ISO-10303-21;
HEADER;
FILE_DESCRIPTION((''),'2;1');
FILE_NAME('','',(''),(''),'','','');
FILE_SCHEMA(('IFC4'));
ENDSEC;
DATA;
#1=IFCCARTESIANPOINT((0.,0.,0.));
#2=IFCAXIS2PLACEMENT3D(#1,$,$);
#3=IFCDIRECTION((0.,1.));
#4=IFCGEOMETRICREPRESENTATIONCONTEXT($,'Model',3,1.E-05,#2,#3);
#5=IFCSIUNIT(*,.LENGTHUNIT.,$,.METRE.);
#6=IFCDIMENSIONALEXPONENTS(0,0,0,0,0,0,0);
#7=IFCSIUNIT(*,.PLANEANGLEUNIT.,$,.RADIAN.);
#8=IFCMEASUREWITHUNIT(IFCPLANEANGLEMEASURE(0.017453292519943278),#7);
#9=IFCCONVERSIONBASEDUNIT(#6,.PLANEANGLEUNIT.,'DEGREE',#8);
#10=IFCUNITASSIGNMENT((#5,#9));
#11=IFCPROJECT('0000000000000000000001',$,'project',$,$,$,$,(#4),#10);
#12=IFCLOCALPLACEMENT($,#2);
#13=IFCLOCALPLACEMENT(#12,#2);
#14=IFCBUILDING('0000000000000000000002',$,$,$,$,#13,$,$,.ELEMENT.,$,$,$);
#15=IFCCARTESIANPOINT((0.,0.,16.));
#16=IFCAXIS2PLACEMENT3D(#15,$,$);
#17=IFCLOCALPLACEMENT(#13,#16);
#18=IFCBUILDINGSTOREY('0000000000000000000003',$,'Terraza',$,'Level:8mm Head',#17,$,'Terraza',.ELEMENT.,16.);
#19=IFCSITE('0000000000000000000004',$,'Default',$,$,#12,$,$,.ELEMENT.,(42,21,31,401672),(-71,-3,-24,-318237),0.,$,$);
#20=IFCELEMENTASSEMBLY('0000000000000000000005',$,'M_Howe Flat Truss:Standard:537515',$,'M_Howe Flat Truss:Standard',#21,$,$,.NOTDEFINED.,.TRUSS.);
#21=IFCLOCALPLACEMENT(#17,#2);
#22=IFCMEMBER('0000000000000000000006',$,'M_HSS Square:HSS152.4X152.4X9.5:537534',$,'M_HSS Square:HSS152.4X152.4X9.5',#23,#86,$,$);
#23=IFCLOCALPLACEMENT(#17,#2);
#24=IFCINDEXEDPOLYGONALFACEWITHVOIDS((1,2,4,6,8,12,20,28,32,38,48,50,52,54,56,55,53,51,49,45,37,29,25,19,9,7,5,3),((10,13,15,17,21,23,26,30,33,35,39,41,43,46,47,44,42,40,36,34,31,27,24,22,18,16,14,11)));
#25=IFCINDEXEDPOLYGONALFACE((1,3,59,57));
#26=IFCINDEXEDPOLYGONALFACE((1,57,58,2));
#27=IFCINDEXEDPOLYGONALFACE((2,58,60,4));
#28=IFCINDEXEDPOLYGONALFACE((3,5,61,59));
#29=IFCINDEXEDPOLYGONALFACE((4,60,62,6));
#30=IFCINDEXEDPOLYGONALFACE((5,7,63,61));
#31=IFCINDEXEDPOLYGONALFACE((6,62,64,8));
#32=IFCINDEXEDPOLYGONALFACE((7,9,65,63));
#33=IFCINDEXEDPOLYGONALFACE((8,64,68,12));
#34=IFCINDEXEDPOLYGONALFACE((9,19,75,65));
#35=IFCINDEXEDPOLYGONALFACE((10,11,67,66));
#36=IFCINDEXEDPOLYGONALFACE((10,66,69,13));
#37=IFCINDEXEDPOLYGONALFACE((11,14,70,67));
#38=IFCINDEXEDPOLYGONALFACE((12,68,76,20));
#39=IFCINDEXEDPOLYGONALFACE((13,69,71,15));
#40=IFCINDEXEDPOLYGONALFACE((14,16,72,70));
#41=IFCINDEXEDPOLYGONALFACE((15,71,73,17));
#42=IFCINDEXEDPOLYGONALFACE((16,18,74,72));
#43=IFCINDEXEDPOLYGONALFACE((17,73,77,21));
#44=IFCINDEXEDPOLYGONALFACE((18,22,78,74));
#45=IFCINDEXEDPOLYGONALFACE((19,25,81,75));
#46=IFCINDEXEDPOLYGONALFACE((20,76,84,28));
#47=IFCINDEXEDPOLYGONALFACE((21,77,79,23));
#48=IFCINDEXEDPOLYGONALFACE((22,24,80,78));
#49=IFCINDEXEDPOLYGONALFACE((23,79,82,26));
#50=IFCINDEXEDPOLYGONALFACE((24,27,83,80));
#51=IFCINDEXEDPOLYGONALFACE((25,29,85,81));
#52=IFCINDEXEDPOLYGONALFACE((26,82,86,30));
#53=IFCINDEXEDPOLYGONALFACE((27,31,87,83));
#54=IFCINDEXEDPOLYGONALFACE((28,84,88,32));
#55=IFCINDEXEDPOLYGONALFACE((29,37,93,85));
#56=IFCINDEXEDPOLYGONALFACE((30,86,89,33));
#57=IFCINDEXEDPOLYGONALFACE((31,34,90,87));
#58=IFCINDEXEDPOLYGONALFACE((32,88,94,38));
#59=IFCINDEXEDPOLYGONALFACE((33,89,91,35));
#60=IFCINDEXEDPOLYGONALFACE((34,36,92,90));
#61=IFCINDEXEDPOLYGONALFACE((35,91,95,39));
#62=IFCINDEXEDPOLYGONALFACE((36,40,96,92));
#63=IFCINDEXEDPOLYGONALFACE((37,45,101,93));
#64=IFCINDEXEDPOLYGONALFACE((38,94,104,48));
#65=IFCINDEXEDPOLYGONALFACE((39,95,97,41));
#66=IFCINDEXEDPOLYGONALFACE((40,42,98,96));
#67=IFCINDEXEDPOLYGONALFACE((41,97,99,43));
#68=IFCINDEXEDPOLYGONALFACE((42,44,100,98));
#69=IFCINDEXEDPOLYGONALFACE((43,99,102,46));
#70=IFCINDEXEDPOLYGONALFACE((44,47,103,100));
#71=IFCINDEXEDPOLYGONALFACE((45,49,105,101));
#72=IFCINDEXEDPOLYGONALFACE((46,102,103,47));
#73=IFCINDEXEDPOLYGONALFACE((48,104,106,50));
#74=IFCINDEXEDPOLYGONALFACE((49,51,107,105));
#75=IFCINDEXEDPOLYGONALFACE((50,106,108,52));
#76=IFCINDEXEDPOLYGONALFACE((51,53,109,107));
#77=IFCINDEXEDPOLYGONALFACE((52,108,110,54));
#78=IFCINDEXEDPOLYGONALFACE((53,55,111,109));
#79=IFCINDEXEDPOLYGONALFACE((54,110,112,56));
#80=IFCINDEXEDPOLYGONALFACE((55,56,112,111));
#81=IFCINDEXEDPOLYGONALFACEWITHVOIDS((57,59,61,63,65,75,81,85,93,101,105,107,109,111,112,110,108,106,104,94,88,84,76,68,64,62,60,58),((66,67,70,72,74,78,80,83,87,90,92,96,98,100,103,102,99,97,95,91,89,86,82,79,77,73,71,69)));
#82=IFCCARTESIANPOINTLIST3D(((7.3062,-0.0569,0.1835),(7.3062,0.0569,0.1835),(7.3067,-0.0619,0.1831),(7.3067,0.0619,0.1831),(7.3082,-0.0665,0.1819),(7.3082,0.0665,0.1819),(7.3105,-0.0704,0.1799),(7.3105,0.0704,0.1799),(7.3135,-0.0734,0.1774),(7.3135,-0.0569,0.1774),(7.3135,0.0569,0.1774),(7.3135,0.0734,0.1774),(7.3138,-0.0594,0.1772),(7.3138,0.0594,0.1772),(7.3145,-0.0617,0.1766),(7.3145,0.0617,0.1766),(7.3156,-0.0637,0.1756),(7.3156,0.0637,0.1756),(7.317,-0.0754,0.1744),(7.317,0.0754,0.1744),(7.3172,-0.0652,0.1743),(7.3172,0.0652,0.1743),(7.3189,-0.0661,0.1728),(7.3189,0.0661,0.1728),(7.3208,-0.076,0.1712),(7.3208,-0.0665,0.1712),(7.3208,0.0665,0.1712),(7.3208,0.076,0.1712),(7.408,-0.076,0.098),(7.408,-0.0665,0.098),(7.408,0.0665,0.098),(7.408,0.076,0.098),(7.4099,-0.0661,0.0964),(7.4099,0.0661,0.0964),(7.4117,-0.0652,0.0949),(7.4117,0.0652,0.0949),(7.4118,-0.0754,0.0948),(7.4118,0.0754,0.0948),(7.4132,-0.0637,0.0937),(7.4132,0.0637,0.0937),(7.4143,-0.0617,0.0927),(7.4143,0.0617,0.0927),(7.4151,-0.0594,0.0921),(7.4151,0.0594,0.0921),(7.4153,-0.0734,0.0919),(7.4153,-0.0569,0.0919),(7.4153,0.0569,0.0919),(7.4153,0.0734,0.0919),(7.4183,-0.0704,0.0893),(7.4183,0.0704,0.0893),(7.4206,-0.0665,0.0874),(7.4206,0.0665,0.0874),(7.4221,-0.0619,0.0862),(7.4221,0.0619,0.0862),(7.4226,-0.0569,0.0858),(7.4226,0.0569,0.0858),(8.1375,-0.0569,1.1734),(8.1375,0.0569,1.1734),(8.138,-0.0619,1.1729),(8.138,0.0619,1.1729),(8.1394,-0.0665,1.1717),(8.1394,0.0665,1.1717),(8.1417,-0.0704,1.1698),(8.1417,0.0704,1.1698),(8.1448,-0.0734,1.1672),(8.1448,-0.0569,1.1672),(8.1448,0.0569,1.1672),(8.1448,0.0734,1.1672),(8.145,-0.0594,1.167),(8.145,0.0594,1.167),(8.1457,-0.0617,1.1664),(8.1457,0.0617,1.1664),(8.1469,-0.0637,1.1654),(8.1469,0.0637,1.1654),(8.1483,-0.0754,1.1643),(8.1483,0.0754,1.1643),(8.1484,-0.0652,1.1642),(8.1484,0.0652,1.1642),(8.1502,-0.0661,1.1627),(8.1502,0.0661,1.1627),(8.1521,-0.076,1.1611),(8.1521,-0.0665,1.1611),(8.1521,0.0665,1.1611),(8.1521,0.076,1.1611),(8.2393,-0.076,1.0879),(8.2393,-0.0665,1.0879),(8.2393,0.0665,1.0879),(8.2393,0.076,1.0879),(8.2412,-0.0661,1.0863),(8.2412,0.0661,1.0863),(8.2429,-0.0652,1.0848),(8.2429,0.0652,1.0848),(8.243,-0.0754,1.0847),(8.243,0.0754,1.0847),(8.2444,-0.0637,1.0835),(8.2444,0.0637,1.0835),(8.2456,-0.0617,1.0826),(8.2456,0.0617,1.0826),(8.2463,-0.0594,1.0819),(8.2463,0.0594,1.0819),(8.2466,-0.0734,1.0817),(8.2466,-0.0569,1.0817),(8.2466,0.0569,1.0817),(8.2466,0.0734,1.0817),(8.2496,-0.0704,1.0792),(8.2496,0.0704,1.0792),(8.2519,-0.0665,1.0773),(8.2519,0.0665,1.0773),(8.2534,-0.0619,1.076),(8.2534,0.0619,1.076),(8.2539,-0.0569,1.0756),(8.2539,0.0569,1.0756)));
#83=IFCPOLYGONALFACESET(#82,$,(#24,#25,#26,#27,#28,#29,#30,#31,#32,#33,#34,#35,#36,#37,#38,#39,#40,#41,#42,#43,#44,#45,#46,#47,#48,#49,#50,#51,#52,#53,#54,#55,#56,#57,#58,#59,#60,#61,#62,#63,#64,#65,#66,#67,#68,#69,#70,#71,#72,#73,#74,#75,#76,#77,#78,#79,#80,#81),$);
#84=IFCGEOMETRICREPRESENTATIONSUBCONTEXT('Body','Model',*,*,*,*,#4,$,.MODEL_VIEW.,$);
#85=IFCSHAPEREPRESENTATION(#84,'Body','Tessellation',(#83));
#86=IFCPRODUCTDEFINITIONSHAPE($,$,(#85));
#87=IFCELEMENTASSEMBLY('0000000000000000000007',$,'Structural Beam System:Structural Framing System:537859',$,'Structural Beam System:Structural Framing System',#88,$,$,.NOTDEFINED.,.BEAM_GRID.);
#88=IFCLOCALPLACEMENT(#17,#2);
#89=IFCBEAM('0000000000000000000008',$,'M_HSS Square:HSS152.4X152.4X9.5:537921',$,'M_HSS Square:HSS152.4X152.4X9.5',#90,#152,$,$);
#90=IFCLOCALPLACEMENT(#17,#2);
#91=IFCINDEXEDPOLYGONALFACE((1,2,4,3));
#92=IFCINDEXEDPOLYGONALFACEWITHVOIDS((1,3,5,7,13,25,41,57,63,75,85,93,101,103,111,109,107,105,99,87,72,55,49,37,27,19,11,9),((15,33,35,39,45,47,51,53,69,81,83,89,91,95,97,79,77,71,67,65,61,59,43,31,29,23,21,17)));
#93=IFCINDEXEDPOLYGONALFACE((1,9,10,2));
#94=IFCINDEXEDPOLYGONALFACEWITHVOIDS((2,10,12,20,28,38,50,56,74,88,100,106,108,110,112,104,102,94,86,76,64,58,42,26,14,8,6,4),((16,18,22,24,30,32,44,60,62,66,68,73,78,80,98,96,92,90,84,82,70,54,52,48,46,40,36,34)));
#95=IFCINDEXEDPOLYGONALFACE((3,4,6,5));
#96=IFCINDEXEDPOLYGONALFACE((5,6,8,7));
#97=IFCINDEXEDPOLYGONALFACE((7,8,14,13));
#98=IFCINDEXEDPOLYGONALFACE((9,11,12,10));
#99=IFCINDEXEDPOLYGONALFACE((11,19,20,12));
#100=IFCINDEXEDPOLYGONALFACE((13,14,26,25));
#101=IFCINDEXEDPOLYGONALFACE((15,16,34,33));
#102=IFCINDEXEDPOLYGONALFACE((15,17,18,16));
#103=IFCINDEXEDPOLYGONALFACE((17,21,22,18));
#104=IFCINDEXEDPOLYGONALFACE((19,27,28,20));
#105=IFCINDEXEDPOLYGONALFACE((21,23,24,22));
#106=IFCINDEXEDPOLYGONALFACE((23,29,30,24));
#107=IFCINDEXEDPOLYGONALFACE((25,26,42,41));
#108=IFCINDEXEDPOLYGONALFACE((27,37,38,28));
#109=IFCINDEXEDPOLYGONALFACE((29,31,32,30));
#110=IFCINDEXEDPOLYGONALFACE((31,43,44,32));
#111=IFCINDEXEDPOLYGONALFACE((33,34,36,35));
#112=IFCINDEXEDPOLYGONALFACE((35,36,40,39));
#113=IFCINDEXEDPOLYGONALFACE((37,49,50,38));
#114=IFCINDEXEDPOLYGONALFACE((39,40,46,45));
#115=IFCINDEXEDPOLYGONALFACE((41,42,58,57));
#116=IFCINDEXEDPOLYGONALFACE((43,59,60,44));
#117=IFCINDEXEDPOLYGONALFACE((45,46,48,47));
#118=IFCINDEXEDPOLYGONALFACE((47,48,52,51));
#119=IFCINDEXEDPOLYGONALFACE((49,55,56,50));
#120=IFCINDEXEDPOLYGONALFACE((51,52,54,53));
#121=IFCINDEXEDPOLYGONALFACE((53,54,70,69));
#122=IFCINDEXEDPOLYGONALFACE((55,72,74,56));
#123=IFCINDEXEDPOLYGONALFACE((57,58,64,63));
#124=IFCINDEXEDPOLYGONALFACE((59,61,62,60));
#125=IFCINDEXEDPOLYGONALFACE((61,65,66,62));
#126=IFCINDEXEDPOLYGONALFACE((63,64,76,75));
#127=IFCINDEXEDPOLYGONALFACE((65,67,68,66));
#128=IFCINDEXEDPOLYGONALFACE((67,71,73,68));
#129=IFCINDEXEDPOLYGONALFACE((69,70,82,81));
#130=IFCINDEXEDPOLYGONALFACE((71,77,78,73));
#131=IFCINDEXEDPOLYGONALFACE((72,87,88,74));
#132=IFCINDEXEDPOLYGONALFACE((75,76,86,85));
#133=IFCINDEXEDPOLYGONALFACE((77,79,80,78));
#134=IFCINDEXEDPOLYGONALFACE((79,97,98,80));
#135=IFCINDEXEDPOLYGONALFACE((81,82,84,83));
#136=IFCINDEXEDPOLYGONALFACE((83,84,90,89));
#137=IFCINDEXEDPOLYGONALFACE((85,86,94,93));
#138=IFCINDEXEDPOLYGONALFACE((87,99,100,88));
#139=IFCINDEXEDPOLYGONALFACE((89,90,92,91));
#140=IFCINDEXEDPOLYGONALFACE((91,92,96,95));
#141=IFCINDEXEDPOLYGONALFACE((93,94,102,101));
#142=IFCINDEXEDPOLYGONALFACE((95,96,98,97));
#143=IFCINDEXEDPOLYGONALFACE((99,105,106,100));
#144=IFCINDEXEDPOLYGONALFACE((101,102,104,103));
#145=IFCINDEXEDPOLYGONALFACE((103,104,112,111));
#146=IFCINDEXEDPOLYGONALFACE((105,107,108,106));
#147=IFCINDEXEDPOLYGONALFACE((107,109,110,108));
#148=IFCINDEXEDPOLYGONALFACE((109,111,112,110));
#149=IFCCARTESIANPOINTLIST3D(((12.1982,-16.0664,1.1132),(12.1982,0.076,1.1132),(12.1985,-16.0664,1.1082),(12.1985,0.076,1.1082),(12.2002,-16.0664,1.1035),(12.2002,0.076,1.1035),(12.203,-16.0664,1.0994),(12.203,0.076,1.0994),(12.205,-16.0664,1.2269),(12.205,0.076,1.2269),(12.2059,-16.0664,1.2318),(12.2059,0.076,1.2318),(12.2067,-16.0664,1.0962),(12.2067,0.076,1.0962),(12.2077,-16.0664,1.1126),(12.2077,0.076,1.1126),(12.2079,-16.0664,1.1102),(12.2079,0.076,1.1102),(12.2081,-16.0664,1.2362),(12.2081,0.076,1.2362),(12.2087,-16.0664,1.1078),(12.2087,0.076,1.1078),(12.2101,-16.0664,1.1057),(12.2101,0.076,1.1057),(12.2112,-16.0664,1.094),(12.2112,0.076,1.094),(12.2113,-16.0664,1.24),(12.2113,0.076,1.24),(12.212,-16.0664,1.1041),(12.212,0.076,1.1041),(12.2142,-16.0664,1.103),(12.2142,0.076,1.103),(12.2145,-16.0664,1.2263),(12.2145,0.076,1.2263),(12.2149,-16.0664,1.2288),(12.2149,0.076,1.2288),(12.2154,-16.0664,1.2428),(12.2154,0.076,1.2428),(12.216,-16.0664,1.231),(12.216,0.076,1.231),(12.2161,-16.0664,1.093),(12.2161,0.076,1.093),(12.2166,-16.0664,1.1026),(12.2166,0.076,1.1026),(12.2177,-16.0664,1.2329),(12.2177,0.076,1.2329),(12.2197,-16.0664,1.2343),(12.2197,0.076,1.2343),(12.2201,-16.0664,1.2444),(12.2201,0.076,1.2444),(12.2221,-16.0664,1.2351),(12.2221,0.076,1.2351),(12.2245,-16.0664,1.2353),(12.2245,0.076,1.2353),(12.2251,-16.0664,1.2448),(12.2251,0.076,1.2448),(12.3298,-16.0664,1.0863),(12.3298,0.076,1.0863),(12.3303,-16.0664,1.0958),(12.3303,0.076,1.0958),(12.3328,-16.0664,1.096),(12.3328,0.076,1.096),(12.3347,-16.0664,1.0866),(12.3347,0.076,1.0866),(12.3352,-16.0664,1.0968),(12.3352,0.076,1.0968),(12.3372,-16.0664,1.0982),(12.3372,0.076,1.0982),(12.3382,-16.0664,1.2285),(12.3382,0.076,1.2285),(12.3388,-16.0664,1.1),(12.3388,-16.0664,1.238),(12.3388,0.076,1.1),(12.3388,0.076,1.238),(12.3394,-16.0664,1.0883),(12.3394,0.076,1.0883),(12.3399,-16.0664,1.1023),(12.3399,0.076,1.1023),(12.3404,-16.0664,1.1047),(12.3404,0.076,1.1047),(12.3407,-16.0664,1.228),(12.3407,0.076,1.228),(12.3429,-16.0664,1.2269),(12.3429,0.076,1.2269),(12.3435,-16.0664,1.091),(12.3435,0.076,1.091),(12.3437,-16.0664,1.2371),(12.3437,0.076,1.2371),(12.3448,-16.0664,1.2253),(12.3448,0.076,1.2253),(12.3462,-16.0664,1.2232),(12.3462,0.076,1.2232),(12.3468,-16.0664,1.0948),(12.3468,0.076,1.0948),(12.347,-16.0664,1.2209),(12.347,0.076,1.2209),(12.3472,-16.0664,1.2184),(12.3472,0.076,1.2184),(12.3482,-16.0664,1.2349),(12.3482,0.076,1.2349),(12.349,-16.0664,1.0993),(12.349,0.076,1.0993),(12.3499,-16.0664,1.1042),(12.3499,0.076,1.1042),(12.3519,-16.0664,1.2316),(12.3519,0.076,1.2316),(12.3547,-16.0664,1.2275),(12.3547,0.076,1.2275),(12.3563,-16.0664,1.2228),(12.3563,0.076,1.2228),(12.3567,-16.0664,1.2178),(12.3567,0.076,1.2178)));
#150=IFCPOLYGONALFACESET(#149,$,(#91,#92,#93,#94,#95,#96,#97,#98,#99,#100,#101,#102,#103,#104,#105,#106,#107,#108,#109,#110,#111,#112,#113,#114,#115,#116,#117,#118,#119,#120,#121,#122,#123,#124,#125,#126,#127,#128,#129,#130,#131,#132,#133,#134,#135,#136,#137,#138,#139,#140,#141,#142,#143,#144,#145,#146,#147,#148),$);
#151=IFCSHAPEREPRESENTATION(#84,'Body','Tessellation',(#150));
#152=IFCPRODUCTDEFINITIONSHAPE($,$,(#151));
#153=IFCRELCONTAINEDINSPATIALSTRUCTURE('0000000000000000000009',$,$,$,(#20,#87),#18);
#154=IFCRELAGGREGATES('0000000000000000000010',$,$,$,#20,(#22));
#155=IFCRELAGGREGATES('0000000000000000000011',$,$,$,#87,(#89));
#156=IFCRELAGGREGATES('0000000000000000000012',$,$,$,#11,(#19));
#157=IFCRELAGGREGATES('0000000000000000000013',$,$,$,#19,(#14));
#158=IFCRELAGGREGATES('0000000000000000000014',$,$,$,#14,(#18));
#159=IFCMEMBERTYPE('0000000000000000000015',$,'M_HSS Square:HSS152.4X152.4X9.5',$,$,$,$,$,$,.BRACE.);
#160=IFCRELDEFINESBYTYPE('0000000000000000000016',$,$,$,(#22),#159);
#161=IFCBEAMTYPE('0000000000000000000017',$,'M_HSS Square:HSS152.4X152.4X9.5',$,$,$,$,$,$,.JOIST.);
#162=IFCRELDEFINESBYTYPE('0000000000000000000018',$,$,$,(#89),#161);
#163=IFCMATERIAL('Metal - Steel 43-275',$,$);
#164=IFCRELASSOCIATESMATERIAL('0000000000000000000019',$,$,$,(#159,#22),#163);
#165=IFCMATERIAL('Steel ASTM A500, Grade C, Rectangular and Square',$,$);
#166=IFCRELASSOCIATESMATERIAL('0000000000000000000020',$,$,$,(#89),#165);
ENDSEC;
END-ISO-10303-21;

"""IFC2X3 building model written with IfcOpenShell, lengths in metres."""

from ifc_helpers import new_model, entity, si_unit, converted_unit, direction, frame, frame_2d, origin, place, context, subcontext, project, spatial, polyline, circle_curve, parameter, trimmed, segment, composite_curve, outline, extrude, source, transform, mapped, material, type_object, type_shapes, element, aggregate, save


model = new_model("IFC2X3")

# Units and contexts
model_context = context("Model", 3, precision=1e-05, world=origin(), true_north=direction((0.0, 1.0)))
body_context = subcontext(model_context, "Body", "Model", "MODEL_VIEW")
ifc_project = project(units=[si_unit("LENGTHUNIT", "METRE"), converted_unit("PLANEANGLEUNIT", "DEGREE", entity("IfcPlaneAngleMeasure", 0.017453292519943278), si_unit("PLANEANGLEUNIT", "RADIAN"), dimensions=[0, 0, 0, 0, 0, 0, 0])], contexts=[model_context])

# Site, building, storey
site_placement = place(None, origin())
site = spatial("IfcSite", under=ifc_project, at=site_placement, Name="Default", CompositionType="ELEMENT", RefLatitude=(42, 21, 31, 401672), RefLongitude=(-71, -3, -24, -318237), RefElevation=0.0)
building_placement = place(site_placement, origin())
building = spatial("IfcBuilding", under=site, at=building_placement, CompositionType="ELEMENT")
storey_placement = place(building_placement, frame((0.0, 0.0, 16.0)))
storey = spatial("IfcBuildingStorey", under=building, at=storey_placement, Name="Terraza", ObjectType="Level:8mm Head", LongName="Terraza", CompositionType="ELEMENT", Elevation=16.0)

# Element assembly
ifc_material_1 = material(Name="Metal - Steel 43-275")
assembly_1_placement = place(storey_placement, origin())
assembly_1 = element("IfcElementAssembly", 1, at=assembly_1_placement, inside=storey, Name="M_Howe Flat Truss:Standard:537515", ObjectType="M_Howe Flat Truss:Standard", AssemblyPlace="NOTDEFINED", PredefinedType="TRUSS")

# Member
member_type_1 = type_object("IfcMemberType", Name="M_HSS Square:HSS152.4X152.4X9.5", PredefinedType="BRACE", material=ifc_material_1)
shared_shape_1 = source(origin(), body_context, "Body", "SweptSolid", [
    extrude(outline(composite_curve([segment(polyline([(-0.0569, -0.076), (0.0569, -0.076)]), True, "CONTINUOUS"), segment(trimmed(circle_curve(frame_2d((0.0569, -0.0569), x_axis=(0.0, 1.0)), 0.0191), [parameter(180.0)], [parameter(270.0)], True, "PARAMETER"), True, "CONTINUOUS"), segment(polyline([(0.076, -0.0569), (0.076, 0.0569)]), True, "CONTINUOUS"), segment(trimmed(circle_curve(frame_2d((0.0569, 0.0569), x_axis=(0.0, 1.0)), 0.0191), [parameter(270.0)], [parameter(0.0)], True, "PARAMETER"), True, "CONTINUOUS"), segment(polyline([(0.0569, 0.076), (-0.0569, 0.076)]), True, "CONTINUOUS"), segment(trimmed(circle_curve(frame_2d((-0.0569, 0.0569), x_axis=(0.0, 1.0)), 0.0191), [parameter(0.0)], [parameter(90.0)], True, "PARAMETER"), True, "CONTINUOUS"), segment(polyline([(-0.076, 0.0569), (-0.076, -0.0569)]), True, "CONTINUOUS"), segment(trimmed(circle_curve(frame_2d((-0.0569, -0.0569), x_axis=(0.0, 1.0)), 0.0191), [parameter(90.0)], [parameter(180.0)], True, "PARAMETER"), True, "CONTINUOUS")], self_intersect=False), holes=[composite_curve([segment(trimmed(circle_curve(frame_2d((-0.0569, 0.0569), x_axis=(0.0, 1.0)), 0.0095), [parameter(360.0)], [parameter(90.0)], True, "PARAMETER"), False, "CONTINUOUS"), segment(polyline([(-0.0569, 0.0665), (0.0569, 0.0665)]), True, "CONTINUOUS"), segment(trimmed(circle_curve(frame_2d((0.0569, 0.0569), x_axis=(0.0, 1.0)), 0.0095), [parameter(270.0)], [parameter(360.0)], True, "PARAMETER"), False, "CONTINUOUS"), segment(polyline([(0.0665, 0.0569), (0.0665, -0.0569)]), True, "CONTINUOUS"), segment(trimmed(circle_curve(frame_2d((0.0569, -0.0569), x_axis=(0.0, 1.0)), 0.0095), [parameter(180.0)], [parameter(270.0)], True, "PARAMETER"), False, "CONTINUOUS"), segment(polyline([(0.0569, -0.0665), (-0.0569, -0.0665)]), True, "CONTINUOUS"), segment(trimmed(circle_curve(frame_2d((-0.0569, -0.0569), x_axis=(0.0, 1.0)), 0.0095), [parameter(90.0)], [parameter(180.0)], True, "PARAMETER"), False, "CONTINUOUS"), segment(polyline([(-0.0665, -0.0569), (-0.0665, 0.0569)]), True, "CONTINUOUS")], self_intersect=False)]), frame((-0.6404, 0.0, 0.0), z_axis=(1.0, 0.0, 0.0), x_axis=(0.0, 0.0, -1.0)), (0.0, 0.0, 1.0), 1.2926),
])
type_shapes(member_type_1, [shared_shape_1])
member_1_placement = place(assembly_1_placement, frame((7.7762, 0.0, 0.625), z_axis=(0.765786, 0.0, -0.643096), x_axis=(0.643096, 0.0, 0.765786)))
member_1 = element("IfcMember", 2, at=member_1_placement, type_object=member_type_1, material=ifc_material_1, Name="M_HSS Square:HSS152.4X152.4X9.5:537534", ObjectType="M_HSS Square:HSS152.4X152.4X9.5", context=body_context, shape_type="MappedRepresentation", body=[
    mapped(shared_shape_1, transform((0.0, 0.0, 0.0), scale=1.0)),
])
aggregate(assembly_1, [member_1])

# Element assembly, beam
assembly_2_placement = place(storey_placement, origin())
assembly_2 = element("IfcElementAssembly", 3, at=assembly_2_placement, inside=storey, Name="Structural Beam System:Structural Framing System:537859", ObjectType="Structural Beam System:Structural Framing System", AssemblyPlace="NOTDEFINED", PredefinedType="BEAM_GRID")
ifc_material_2 = material(Name="Steel ASTM A500, Grade C, Rectangular and Square")
beam_type = type_object("IfcBeamType", Name="M_HSS Square:HSS152.4X152.4X9.5", PredefinedType="JOIST")
beam_1_placement = place(assembly_2_placement, frame((12.2729, 0.076, 1.0897), z_axis=(0.0, 0.0, 1.0), x_axis=(0.0, -1.0, 0.0)))
beam_1 = element("IfcBeam", 4, at=beam_1_placement, type_object=beam_type, material=ifc_material_2, Name="M_HSS Square:HSS152.4X152.4X9.5:537921", ObjectType="M_HSS Square:HSS152.4X152.4X9.5", context=body_context, shape_type="SweptSolid", body=[
    extrude(outline(composite_curve([segment(polyline([(-0.0569, -0.076), (0.0569, -0.076)]), True, "CONTINUOUS"), segment(trimmed(circle_curve(frame_2d((0.0569, -0.0569), x_axis=(0.0, 1.0)), 0.0191), [parameter(180.0)], [parameter(270.0)], True, "PARAMETER"), True, "CONTINUOUS"), segment(polyline([(0.076, -0.0569), (0.076, 0.0569)]), True, "CONTINUOUS"), segment(trimmed(circle_curve(frame_2d((0.0569, 0.0569), x_axis=(0.0, 1.0)), 0.0191), [parameter(270.0)], [parameter(0.0)], True, "PARAMETER"), True, "CONTINUOUS"), segment(polyline([(0.0569, 0.076), (-0.0569, 0.076)]), True, "CONTINUOUS"), segment(trimmed(circle_curve(frame_2d((-0.0569, 0.0569), x_axis=(0.0, 1.0)), 0.0191), [parameter(0.0)], [parameter(90.0)], True, "PARAMETER"), True, "CONTINUOUS"), segment(polyline([(-0.076, 0.0569), (-0.076, -0.0569)]), True, "CONTINUOUS"), segment(trimmed(circle_curve(frame_2d((-0.0569, -0.0569), x_axis=(0.0, 1.0)), 0.0191), [parameter(90.0)], [parameter(180.0)], True, "PARAMETER"), True, "CONTINUOUS")], self_intersect=False), holes=[composite_curve([segment(trimmed(circle_curve(frame_2d((-0.0569, 0.0569), x_axis=(0.0, 1.0)), 0.0095), [parameter(360.0)], [parameter(90.0)], True, "PARAMETER"), False, "CONTINUOUS"), segment(polyline([(-0.0569, 0.0665), (0.0569, 0.0665)]), True, "CONTINUOUS"), segment(trimmed(circle_curve(frame_2d((0.0569, 0.0569), x_axis=(0.0, 1.0)), 0.0095), [parameter(270.0)], [parameter(360.0)], True, "PARAMETER"), False, "CONTINUOUS"), segment(polyline([(0.0665, 0.0569), (0.0665, -0.0569)]), True, "CONTINUOUS"), segment(trimmed(circle_curve(frame_2d((0.0569, -0.0569), x_axis=(0.0, 1.0)), 0.0095), [parameter(180.0)], [parameter(270.0)], True, "PARAMETER"), False, "CONTINUOUS"), segment(polyline([(0.0569, -0.0665), (-0.0569, -0.0665)]), True, "CONTINUOUS"), segment(trimmed(circle_curve(frame_2d((-0.0569, -0.0569), x_axis=(0.0, 1.0)), 0.0095), [parameter(90.0)], [parameter(180.0)], True, "PARAMETER"), False, "CONTINUOUS"), segment(polyline([(-0.0665, -0.0569), (-0.0665, 0.0569)]), True, "CONTINUOUS")], self_intersect=False)]), frame((0.0, 0.0045, 0.0759), z_axis=(1.0, 0.0, 0.0), x_axis=(0.0, -0.059434, -0.998232)), (0.0, 0.0, 1.0), 16.1424),
])
aggregate(assembly_2, [beam_1])

save(model, "model.ifc")
